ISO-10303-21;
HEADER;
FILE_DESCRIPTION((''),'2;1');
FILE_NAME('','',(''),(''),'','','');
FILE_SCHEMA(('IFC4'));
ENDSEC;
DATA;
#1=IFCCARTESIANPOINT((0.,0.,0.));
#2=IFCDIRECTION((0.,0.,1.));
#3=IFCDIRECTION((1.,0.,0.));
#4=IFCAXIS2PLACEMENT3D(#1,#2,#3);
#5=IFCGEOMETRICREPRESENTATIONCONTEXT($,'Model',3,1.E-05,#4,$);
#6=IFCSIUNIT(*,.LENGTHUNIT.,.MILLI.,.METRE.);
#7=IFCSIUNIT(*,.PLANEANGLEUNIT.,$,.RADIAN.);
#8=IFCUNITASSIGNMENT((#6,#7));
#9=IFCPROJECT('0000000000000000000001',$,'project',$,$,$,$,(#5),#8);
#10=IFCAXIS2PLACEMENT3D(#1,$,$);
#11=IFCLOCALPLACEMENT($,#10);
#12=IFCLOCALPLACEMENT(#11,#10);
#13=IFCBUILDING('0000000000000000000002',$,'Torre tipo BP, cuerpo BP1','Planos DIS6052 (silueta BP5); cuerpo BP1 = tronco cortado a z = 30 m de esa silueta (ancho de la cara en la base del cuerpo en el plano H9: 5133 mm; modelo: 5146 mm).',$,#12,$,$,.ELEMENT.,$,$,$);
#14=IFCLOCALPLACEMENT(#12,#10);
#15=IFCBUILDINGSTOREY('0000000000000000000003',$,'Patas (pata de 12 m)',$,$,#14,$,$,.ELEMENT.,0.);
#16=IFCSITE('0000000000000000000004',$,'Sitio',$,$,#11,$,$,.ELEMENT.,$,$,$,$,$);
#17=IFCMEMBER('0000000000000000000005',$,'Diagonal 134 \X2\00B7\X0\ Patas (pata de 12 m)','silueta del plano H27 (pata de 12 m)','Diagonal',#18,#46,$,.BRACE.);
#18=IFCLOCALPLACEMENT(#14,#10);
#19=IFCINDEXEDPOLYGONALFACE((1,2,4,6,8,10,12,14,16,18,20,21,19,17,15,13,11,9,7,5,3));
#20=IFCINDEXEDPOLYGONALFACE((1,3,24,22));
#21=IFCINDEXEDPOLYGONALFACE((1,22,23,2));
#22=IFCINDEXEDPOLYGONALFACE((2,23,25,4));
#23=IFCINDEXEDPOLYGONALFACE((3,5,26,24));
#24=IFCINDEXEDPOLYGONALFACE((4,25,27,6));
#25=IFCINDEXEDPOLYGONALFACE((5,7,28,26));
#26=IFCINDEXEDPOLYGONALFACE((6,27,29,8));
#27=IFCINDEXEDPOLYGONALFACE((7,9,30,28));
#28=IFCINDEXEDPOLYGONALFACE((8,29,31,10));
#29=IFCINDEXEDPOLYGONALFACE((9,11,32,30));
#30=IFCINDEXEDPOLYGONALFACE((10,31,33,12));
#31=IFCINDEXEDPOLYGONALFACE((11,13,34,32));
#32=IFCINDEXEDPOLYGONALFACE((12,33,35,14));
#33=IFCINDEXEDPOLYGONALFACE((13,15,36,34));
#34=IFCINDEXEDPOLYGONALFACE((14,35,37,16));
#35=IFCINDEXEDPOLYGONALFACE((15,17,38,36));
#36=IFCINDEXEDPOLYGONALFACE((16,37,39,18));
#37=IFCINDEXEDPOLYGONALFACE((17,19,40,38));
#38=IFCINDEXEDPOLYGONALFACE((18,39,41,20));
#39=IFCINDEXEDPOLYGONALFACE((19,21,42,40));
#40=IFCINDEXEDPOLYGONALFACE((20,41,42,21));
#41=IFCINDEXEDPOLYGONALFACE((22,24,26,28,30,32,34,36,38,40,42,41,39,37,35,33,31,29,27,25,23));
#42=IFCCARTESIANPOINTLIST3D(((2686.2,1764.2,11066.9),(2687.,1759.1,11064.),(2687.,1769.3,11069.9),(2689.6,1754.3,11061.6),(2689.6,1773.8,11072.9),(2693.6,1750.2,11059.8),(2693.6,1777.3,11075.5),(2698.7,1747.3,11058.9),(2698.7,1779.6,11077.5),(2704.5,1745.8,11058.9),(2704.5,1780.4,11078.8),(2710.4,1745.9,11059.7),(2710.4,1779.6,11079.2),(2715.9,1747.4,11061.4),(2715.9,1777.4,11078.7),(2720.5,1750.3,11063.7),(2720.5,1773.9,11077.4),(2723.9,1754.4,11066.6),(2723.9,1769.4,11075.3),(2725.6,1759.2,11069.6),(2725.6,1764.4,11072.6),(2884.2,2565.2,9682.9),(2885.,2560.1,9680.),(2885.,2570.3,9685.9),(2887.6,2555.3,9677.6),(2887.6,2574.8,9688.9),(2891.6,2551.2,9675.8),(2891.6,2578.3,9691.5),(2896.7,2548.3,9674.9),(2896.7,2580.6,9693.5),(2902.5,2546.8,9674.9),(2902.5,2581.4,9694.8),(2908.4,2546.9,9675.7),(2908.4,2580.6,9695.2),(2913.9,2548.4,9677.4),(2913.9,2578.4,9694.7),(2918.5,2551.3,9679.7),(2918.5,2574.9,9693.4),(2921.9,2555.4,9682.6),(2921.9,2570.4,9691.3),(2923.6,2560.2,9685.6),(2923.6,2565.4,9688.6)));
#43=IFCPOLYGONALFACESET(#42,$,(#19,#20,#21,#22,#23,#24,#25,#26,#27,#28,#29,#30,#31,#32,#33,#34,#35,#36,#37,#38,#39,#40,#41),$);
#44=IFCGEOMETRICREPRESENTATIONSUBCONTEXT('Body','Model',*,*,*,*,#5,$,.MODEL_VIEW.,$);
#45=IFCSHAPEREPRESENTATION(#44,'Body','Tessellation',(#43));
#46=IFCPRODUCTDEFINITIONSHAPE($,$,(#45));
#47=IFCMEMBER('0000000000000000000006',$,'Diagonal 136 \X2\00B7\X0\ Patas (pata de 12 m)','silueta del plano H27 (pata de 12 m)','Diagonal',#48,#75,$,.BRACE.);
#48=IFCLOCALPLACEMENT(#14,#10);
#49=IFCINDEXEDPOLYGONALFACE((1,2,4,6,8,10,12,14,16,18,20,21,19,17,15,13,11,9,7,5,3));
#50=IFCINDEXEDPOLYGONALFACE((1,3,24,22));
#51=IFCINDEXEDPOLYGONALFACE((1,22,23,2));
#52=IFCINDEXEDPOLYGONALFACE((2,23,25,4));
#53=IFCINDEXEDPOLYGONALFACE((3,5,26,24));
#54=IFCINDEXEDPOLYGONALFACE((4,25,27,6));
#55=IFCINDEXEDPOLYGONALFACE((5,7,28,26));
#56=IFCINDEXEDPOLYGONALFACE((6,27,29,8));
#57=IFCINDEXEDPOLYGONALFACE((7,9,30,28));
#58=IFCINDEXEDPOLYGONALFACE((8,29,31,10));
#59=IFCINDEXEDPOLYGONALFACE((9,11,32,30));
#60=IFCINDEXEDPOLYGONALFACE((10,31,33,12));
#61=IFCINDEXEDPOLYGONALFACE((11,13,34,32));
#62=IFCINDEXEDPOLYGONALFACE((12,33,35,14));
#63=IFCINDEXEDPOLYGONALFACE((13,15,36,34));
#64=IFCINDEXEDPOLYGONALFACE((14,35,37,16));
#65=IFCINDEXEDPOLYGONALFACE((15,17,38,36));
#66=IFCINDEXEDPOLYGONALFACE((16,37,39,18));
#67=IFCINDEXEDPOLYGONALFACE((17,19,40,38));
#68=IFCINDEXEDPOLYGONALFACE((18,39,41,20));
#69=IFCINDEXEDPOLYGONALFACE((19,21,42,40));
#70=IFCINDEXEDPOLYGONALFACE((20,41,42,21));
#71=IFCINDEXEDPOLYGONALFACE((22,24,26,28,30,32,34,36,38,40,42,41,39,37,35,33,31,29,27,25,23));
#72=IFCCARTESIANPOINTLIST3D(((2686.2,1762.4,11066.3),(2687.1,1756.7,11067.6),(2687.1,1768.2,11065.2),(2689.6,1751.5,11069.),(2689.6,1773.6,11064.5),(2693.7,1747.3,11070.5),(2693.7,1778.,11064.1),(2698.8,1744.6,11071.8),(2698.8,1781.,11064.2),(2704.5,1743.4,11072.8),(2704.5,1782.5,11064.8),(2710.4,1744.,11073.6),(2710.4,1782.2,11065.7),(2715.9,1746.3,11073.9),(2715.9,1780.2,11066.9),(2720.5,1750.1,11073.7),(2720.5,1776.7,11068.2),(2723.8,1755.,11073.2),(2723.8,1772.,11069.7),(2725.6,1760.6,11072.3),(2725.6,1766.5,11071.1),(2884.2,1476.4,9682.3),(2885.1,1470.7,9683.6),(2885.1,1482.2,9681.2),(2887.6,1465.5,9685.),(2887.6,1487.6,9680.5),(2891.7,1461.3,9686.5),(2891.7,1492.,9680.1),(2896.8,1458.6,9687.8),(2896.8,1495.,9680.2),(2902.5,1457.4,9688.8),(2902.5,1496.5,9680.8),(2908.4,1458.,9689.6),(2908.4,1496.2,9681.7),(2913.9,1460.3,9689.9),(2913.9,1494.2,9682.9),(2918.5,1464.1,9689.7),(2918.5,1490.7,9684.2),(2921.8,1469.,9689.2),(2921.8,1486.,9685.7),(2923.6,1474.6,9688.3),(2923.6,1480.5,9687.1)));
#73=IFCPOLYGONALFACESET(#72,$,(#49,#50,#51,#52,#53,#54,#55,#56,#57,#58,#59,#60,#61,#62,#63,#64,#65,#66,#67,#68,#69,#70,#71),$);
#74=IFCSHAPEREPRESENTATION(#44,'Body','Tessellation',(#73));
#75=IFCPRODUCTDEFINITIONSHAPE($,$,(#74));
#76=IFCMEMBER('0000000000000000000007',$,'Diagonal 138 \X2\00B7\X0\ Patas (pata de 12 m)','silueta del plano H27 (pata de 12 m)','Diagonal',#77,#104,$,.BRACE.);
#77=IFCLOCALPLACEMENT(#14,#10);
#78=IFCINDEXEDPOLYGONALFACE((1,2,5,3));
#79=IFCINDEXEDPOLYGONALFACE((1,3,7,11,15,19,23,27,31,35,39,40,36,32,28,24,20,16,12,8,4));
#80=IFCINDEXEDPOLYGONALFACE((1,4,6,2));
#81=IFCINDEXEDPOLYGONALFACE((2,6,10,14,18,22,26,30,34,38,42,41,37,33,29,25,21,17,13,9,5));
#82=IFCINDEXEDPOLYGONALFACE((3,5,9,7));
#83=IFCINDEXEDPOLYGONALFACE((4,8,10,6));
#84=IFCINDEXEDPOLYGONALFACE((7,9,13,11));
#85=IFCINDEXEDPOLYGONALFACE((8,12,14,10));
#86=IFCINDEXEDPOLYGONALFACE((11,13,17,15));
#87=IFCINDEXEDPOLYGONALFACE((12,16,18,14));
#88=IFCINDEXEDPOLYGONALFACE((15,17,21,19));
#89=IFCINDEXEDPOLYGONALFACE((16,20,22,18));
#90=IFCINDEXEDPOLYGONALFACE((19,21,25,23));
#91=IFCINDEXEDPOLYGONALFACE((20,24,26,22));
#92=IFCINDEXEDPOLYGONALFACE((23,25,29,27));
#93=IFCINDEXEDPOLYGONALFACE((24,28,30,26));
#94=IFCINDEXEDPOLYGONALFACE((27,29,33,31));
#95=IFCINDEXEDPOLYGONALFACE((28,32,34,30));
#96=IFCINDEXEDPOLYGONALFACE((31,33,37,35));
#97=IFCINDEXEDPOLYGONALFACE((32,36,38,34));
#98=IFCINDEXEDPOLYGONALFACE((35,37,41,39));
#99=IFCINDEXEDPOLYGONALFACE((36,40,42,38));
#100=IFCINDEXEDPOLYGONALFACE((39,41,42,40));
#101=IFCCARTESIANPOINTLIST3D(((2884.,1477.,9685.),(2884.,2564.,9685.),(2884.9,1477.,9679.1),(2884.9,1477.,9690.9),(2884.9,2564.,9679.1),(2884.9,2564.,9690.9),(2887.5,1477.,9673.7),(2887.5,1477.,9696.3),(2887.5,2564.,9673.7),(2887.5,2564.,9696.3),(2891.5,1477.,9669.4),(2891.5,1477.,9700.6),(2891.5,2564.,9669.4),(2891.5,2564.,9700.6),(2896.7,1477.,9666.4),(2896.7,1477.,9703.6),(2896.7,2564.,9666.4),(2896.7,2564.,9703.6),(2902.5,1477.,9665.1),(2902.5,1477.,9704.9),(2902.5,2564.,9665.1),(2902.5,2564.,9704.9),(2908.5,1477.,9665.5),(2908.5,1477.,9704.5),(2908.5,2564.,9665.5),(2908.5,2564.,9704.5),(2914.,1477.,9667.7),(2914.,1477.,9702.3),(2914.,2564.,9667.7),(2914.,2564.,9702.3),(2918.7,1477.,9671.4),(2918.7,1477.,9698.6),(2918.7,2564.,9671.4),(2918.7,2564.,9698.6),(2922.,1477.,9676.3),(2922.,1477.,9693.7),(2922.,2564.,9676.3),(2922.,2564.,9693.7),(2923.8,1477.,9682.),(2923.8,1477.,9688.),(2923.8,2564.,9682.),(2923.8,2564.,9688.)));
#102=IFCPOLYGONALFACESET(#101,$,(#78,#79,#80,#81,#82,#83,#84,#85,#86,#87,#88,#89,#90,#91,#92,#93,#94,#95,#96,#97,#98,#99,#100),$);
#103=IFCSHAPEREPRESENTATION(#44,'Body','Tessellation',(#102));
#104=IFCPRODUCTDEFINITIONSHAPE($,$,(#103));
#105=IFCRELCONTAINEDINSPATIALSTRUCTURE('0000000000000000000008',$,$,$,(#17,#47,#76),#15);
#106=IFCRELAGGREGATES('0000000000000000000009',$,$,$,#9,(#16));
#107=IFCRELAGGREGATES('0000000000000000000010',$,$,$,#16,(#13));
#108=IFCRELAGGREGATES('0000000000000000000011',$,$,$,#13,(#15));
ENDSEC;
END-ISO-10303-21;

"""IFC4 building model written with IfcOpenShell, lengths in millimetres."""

from ifc_helpers import new_model, si_unit, frame, origin, origin_with_axes, place, context, subcontext, project, spatial, circle, extrude, element, save


model = new_model("IFC4")

# Units and contexts
model_context = context("Model", 3, precision=1e-05, world=origin_with_axes())
body_context = subcontext(model_context, "Body", "Model", "MODEL_VIEW")
ifc_project = project(units=[si_unit("LENGTHUNIT", "METRE", prefix="MILLI"), si_unit("PLANEANGLEUNIT", "RADIAN")], contexts=[model_context])

# Site, building, storey
site_placement = place(None, origin())
site = spatial("IfcSite", under=ifc_project, at=site_placement, Name="Sitio", CompositionType="ELEMENT")
building_placement = place(site_placement, origin())
building = spatial("IfcBuilding", under=site, at=building_placement, Name="Torre tipo BP, cuerpo BP1", Description="Planos DIS6052 (silueta BP5); cuerpo BP1 = tronco cortado a z = 30 m de esa silueta (ancho de la cara en la base del cuerpo en el plano H9: 5133 mm; modelo: 5146 mm).", CompositionType="ELEMENT")
storey_placement = place(building_placement, origin())
storey = spatial("IfcBuildingStorey", under=building, at=storey_placement, Name="Patas (pata de 12 m)", CompositionType="ELEMENT", Elevation=0.0)

# Members
member_1_placement = place(storey_placement, frame((2904.0, 2564.0, 9685.0), z_axis=(-0.122883, -0.497117, 0.858938), x_axis=(-0.992421, 0.061554, -0.106355)))
element("IfcMember", 1, at=member_1_placement, inside=storey, Name="Diagonal 134 · Patas (pata de 12 m)", Description="silueta del plano H27 (pata de 12 m)", ObjectType="Diagonal", PredefinedType="BRACE", context=body_context, shape_type="SweptSolid", body=[
    extrude(circle(Radius=20.0), None, (0.0, 0.0, 1.0), 1611.3),
])
member_2_placement = place(storey_placement, frame((2706.0, 1763.0, 11069.0), z_axis=(0.138748, -0.200414, -0.969837), x_axis=(-0.990328, -0.028079, -0.135877)))
element("IfcMember", 2, at=member_2_placement, inside=storey, Name="Diagonal 136 · Patas (pata de 12 m)", Description="silueta del plano H27 (pata de 12 m)", ObjectType="Diagonal", PredefinedType="BRACE", context=body_context, shape_type="SweptSolid", body=[
    extrude(circle(Radius=20.0), None, (0.0, 0.0, 1.0), 1427.0),
])
member_3_placement = place(storey_placement, frame((2904.0, 1477.0, 9685.0), z_axis=(0.0, 1.0, 0.0), x_axis=(-1.0, 0.0, 0.0)))
element("IfcMember", 3, at=member_3_placement, inside=storey, Name="Diagonal 138 · Patas (pata de 12 m)", Description="silueta del plano H27 (pata de 12 m)", ObjectType="Diagonal", PredefinedType="BRACE", context=body_context, shape_type="SweptSolid", body=[
    extrude(circle(Radius=20.0), None, (0.0, 0.0, 1.0), 1087.0),
])

save(model, "model.ifc")
